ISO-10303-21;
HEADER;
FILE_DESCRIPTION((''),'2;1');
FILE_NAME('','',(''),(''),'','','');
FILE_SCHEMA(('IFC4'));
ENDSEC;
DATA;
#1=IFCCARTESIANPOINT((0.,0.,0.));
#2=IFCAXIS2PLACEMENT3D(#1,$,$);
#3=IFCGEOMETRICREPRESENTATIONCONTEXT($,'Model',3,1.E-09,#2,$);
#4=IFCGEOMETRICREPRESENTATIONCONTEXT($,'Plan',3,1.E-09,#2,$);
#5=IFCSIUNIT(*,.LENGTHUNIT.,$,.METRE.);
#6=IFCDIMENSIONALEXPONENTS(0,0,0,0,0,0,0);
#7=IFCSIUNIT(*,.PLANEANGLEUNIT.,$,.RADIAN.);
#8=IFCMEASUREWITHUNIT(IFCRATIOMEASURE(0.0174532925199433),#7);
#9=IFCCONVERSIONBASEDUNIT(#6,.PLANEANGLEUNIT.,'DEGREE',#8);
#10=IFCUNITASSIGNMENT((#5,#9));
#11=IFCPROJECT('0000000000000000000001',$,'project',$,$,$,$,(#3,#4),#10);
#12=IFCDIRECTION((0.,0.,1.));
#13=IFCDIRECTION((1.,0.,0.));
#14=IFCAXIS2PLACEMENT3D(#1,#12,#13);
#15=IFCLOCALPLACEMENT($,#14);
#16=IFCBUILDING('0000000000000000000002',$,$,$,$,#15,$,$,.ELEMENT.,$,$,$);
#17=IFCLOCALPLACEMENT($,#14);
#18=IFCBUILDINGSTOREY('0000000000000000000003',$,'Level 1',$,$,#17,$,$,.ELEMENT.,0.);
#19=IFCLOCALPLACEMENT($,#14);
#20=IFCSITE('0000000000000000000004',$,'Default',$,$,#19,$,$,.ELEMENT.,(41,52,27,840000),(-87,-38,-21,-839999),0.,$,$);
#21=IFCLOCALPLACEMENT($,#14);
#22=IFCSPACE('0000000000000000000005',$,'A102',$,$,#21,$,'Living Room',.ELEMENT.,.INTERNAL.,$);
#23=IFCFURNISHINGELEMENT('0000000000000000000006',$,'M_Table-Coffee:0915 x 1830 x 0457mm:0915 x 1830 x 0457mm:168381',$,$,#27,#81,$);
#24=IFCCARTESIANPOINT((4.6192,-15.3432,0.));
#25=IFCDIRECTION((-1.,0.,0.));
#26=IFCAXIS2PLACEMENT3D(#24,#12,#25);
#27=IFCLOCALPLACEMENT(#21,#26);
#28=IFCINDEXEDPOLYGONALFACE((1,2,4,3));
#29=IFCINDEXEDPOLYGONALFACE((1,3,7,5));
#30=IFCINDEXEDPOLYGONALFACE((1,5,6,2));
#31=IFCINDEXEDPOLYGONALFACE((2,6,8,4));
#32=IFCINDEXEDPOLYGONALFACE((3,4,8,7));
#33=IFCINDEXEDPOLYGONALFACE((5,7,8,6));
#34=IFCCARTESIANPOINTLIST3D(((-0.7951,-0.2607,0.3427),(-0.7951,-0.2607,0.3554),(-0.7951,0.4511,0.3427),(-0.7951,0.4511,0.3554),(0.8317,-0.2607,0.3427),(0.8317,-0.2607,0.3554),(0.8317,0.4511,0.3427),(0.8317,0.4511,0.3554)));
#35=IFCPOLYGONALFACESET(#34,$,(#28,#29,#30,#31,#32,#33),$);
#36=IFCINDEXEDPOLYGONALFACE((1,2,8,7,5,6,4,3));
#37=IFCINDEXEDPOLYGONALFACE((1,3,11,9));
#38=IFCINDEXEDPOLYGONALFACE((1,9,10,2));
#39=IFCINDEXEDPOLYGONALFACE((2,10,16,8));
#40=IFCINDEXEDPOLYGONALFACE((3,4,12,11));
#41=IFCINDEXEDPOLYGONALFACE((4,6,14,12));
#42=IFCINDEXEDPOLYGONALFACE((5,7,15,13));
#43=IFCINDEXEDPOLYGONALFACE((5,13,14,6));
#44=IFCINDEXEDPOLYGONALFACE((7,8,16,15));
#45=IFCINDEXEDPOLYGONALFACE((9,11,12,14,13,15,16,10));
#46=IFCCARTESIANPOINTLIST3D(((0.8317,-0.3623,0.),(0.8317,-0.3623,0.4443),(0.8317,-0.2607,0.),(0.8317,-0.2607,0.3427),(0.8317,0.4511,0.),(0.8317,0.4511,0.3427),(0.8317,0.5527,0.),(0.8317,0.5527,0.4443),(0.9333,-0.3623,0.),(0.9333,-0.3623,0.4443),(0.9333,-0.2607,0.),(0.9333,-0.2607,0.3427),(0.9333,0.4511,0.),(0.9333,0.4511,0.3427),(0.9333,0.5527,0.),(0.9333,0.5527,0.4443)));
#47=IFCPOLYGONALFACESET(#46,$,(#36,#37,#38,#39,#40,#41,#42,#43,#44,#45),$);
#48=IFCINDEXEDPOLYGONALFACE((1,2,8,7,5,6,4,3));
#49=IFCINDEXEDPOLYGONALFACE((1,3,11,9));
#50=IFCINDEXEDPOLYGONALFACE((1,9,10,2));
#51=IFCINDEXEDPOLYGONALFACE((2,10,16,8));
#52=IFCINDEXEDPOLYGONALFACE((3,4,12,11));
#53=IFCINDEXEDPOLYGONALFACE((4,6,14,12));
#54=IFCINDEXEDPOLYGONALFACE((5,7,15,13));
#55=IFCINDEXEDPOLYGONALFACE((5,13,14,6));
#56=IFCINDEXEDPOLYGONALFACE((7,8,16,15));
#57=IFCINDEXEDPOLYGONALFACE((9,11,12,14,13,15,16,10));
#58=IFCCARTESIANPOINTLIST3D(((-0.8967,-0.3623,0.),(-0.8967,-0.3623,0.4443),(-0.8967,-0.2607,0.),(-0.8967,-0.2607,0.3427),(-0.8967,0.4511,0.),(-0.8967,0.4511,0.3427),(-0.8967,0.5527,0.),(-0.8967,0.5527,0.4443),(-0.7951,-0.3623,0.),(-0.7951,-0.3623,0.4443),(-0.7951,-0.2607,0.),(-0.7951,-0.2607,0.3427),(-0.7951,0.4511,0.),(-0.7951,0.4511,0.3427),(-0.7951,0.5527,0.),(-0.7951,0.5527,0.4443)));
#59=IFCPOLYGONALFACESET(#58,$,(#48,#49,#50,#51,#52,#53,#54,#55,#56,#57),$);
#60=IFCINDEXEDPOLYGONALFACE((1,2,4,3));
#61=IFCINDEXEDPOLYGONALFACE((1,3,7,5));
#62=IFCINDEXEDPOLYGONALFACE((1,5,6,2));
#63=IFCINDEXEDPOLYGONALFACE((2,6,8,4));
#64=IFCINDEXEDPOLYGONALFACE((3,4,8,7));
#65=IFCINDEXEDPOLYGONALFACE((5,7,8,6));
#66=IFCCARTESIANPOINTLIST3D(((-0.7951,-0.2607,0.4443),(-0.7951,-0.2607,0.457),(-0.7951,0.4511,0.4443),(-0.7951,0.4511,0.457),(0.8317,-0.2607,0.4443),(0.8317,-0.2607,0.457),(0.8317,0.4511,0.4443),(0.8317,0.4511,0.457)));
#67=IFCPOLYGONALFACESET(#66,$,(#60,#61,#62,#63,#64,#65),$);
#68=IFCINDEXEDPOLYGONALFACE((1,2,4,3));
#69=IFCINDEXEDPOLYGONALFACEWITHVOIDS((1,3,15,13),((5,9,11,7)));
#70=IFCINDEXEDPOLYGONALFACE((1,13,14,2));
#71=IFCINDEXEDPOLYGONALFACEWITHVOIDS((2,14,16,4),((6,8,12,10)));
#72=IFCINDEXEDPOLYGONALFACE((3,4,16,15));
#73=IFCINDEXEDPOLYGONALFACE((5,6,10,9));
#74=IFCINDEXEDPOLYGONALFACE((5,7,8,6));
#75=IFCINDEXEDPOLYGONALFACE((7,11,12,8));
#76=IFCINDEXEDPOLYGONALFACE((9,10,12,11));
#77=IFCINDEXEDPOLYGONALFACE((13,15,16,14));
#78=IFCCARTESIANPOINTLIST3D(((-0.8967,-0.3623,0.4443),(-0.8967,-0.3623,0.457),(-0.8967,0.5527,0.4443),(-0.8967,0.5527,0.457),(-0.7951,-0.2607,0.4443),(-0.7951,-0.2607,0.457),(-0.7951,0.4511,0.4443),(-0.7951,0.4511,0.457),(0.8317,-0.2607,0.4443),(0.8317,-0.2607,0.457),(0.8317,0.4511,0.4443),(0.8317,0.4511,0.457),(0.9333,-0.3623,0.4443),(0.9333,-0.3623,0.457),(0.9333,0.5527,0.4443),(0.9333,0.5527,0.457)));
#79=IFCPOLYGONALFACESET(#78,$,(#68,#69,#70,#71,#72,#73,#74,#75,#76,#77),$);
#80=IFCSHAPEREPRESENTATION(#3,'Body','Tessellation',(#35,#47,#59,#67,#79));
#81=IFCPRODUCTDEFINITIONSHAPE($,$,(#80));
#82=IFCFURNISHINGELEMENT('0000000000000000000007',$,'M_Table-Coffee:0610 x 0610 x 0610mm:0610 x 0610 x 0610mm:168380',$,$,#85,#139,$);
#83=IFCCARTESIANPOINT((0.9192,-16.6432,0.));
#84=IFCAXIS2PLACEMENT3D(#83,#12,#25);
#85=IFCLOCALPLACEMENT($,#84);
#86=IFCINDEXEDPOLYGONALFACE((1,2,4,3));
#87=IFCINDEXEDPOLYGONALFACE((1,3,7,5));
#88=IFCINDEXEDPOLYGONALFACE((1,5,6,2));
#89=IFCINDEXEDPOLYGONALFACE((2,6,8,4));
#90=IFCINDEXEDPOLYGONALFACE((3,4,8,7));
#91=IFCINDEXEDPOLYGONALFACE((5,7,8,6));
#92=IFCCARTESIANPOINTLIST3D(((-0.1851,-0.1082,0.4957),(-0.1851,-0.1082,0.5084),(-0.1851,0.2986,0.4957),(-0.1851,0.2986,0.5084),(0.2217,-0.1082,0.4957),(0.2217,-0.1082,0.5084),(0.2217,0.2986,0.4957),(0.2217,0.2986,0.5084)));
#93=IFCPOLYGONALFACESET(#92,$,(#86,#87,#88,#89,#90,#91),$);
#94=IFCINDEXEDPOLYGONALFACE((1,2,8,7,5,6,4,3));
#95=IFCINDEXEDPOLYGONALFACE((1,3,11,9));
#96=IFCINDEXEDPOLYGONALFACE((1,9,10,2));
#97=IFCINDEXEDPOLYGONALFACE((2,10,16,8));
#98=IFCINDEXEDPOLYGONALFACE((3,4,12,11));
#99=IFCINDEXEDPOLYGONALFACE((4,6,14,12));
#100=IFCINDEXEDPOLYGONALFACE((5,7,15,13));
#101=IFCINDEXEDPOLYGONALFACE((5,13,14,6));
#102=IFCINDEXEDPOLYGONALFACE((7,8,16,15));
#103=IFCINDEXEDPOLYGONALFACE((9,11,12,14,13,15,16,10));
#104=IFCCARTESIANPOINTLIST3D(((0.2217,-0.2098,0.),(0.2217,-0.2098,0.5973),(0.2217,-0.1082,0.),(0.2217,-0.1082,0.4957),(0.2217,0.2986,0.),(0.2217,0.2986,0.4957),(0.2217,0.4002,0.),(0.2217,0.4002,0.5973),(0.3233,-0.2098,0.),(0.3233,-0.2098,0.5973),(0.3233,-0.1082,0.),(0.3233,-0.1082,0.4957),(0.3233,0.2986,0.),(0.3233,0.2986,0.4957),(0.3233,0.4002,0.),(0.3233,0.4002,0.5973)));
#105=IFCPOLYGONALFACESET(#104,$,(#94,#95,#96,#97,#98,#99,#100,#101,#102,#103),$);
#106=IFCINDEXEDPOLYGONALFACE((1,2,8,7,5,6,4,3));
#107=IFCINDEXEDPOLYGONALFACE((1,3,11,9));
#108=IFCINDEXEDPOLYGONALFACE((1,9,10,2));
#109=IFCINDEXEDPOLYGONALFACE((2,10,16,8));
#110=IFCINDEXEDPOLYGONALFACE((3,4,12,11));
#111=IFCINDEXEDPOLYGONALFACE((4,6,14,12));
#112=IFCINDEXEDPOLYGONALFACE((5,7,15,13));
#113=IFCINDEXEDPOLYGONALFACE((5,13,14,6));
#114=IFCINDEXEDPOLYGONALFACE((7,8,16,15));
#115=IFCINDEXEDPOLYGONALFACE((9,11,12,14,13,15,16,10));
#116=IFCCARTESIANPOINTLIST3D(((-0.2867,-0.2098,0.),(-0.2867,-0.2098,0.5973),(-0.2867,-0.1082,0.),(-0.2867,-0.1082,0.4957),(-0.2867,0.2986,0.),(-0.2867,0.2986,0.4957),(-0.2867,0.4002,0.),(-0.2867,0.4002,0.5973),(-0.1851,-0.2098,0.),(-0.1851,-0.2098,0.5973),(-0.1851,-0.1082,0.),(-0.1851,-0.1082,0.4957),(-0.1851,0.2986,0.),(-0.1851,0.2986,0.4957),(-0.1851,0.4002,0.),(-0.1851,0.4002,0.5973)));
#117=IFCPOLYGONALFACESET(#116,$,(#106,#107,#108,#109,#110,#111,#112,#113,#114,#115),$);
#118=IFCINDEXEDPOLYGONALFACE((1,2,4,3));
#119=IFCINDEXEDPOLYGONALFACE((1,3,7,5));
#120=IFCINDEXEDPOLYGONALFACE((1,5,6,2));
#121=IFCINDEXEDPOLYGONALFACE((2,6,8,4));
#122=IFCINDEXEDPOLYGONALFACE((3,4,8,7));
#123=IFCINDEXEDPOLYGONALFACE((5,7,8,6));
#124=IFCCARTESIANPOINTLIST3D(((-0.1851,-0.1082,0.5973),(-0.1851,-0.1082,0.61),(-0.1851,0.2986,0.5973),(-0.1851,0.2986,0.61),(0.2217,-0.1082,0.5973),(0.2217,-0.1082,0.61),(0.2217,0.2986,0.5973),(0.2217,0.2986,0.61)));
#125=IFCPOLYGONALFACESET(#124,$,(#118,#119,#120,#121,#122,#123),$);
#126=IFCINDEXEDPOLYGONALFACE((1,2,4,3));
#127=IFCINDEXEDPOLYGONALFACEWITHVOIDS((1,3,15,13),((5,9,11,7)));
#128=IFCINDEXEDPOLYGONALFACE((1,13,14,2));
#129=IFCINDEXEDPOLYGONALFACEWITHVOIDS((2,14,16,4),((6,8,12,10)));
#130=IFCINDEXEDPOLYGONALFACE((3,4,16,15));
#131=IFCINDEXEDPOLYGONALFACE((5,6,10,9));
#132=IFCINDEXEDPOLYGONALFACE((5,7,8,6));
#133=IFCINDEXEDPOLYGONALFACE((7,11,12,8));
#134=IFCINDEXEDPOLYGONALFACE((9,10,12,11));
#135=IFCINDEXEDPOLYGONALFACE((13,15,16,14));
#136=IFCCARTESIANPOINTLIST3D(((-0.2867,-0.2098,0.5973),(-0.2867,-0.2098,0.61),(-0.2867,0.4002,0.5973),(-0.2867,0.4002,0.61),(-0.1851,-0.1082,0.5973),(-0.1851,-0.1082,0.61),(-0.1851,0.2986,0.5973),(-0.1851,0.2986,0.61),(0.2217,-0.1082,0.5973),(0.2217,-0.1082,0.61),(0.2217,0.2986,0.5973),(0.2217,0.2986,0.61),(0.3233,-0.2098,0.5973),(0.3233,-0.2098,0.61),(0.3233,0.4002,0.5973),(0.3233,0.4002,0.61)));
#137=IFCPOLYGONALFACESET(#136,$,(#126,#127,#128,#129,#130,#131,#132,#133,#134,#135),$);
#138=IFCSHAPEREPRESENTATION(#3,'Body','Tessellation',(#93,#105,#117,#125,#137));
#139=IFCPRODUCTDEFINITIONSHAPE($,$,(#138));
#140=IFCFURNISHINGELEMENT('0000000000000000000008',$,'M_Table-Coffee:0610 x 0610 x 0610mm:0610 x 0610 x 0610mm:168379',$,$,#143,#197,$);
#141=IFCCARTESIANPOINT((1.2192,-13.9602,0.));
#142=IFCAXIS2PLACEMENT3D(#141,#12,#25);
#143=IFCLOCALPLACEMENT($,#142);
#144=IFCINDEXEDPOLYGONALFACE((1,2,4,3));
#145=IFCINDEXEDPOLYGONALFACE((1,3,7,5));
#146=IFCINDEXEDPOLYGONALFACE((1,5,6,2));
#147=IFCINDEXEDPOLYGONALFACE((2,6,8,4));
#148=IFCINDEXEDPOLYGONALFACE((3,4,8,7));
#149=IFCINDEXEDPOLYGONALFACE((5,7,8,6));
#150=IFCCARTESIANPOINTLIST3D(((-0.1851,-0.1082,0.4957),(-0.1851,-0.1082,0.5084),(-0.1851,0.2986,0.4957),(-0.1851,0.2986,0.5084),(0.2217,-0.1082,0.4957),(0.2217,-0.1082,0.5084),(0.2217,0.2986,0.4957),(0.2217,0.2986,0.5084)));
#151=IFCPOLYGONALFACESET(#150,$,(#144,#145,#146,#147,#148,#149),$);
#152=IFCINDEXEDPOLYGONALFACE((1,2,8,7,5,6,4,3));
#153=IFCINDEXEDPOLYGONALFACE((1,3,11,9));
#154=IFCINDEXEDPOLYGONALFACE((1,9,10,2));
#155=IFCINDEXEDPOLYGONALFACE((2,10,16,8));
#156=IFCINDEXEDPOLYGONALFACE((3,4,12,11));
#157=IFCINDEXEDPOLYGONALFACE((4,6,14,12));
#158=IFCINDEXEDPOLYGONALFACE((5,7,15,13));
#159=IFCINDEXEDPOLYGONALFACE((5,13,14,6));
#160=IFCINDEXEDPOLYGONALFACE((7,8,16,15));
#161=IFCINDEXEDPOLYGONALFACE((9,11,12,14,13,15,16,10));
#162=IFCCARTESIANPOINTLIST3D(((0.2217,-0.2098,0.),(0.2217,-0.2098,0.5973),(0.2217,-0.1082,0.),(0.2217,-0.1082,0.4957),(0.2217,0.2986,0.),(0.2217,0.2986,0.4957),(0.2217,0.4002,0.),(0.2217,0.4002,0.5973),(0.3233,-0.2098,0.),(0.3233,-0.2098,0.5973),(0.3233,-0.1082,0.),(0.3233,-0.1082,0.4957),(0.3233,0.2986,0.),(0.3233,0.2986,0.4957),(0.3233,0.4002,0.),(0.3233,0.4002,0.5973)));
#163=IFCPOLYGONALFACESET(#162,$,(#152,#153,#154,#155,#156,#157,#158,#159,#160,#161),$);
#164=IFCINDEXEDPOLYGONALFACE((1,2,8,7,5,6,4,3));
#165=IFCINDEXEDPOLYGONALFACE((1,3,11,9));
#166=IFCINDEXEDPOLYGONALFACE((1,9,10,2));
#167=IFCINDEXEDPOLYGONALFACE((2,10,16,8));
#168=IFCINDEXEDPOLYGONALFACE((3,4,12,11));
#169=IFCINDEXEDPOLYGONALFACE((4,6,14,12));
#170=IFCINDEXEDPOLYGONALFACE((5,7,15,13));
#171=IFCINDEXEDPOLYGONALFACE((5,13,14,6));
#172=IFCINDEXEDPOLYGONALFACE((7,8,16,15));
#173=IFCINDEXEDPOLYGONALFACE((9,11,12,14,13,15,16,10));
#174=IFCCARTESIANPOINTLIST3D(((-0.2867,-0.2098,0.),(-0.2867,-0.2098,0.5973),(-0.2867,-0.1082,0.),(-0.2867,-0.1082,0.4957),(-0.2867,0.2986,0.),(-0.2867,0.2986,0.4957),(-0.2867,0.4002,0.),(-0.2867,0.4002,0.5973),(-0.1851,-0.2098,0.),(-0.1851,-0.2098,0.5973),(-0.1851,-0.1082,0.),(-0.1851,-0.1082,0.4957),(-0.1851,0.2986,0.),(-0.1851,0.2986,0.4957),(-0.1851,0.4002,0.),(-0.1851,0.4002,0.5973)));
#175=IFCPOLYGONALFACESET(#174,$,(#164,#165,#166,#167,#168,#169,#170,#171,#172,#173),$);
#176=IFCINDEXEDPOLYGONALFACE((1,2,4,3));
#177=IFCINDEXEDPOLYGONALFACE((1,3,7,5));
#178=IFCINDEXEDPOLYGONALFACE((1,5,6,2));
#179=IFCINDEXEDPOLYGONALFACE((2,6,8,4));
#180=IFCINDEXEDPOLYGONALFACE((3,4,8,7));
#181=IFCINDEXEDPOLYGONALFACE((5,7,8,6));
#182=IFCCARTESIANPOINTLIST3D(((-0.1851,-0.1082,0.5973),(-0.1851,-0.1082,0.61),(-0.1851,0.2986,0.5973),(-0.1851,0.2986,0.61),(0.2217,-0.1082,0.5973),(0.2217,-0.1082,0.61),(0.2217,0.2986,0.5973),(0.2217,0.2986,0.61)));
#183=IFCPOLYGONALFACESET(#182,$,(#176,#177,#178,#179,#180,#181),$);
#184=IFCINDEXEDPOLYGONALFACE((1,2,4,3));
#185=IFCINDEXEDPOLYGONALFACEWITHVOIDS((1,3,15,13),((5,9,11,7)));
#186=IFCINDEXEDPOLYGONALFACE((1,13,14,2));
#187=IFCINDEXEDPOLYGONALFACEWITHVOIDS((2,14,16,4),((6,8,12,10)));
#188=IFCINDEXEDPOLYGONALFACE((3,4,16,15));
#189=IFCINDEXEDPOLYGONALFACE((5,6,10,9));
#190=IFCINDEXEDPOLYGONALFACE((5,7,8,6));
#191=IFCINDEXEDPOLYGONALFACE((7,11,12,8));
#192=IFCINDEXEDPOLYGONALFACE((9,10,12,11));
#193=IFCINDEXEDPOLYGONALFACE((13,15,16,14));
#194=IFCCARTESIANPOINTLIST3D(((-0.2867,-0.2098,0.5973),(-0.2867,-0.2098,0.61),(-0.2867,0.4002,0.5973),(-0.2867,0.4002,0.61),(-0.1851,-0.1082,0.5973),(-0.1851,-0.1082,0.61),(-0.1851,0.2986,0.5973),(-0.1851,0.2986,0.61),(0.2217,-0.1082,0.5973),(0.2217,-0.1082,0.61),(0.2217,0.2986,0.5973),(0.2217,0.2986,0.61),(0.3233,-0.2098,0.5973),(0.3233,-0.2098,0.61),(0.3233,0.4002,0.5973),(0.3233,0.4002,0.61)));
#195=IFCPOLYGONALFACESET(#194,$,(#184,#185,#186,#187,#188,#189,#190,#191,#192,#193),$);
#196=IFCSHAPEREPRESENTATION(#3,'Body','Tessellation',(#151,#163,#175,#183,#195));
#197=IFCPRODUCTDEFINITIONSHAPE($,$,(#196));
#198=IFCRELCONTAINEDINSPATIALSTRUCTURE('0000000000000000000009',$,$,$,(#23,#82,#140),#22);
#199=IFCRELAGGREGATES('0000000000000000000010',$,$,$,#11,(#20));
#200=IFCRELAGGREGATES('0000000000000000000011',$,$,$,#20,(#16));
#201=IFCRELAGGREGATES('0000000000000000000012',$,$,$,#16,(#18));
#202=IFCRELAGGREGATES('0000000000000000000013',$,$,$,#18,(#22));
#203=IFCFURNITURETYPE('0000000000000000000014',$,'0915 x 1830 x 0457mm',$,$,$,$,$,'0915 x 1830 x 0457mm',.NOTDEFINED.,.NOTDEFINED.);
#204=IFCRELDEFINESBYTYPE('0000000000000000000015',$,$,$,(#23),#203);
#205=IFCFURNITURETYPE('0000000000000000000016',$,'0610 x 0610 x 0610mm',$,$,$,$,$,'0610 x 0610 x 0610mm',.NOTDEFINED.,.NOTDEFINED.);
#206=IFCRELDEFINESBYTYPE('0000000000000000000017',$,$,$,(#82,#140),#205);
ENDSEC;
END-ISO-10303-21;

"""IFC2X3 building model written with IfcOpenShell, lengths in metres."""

from ifc_helpers import new_model, entity, si_unit, converted_unit, frame, origin, origin_with_axes, origin_2d_with_axis, place, context, project, spatial, polyline, rectangle, outline, extrude, source, transform, mapped, type_object, type_shapes, element, save


model = new_model("IFC2X3")

# Units and contexts
model_context = context("Model", 3, precision=1e-09, world=origin())
plan_context = context("Plan", 3, precision=1e-09, world=origin())
ifc_project = project(units=[si_unit("LENGTHUNIT", "METRE"), converted_unit("PLANEANGLEUNIT", "DEGREE", entity("IfcRatioMeasure", 0.0174532925199433), si_unit("PLANEANGLEUNIT", "RADIAN"), dimensions=[0, 0, 0, 0, 0, 0, 0])], contexts=[model_context, plan_context])

# Site, building, storey, space
site_placement = place(None, origin_with_axes())
site = spatial("IfcSite", under=ifc_project, at=site_placement, Name="Default", CompositionType="ELEMENT", RefLatitude=(41, 52, 27, 840000), RefLongitude=(-87, -38, -21, -839999), RefElevation=0.0)
building_placement = place(None, origin_with_axes())
building = spatial("IfcBuilding", under=site, at=building_placement, CompositionType="ELEMENT")
storey_placement = place(None, origin_with_axes())
storey = spatial("IfcBuildingStorey", under=building, at=storey_placement, Name="Level 1", CompositionType="ELEMENT", Elevation=0.0)
space_placement = place(None, origin_with_axes())
space = spatial("IfcSpace", under=storey, at=space_placement, Name="A102", LongName="Living Room", CompositionType="ELEMENT", InteriorOrExteriorSpace="INTERNAL")

# Furnishing elements
furniture_type_1 = type_object("IfcFurnitureType", Name="0915 x 1830 x 0457mm", ElementType="0915 x 1830 x 0457mm", AssemblyPlace="NOTDEFINED")
shared_shape_1 = source(origin(), model_context, "Body", "SweptSolid", [
    extrude(rectangle(XDim=1.6268, YDim=0.7118, at=origin_2d_with_axis()), frame((0.0183, 0.0952, 0.3427), z_axis=(0.0, 0.0, 1.0), x_axis=(-1.0, 0.0, 0.0)), (0.0, 0.0, 1.0), 0.0127),
    extrude(outline(polyline([(-0.1967, -0.4575), (0.2475, -0.4575), (0.2475, 0.4575), (-0.1967, 0.4575), (-0.1967, 0.3559), (0.146, 0.3559), (0.146, -0.3559), (-0.1967, -0.3559), (-0.1967, -0.4575)])), frame((0.8317, 0.0952, 0.1967), z_axis=(1.0, 0.0, 0.0), x_axis=(0.0, 0.0, 1.0)), (0.0, 0.0, 1.0), 0.1016),
    extrude(outline(polyline([(-0.4575, -0.2476), (0.4575, -0.2476), (0.4575, 0.1968), (0.3559, 0.1968), (0.3559, -0.1459), (-0.3559, -0.1459), (-0.3559, 0.1968), (-0.4575, 0.1968), (-0.4575, -0.2476)])), frame((-0.8967, 0.0952, 0.1968), z_axis=(1.0, 0.0, 0.0), x_axis=(0.0, -1.0, 0.0)), (0.0, 0.0, 1.0), 0.1016),
    extrude(rectangle(XDim=1.6268, YDim=0.7118, at=origin_2d_with_axis()), frame((0.0183, 0.0952, 0.4443), z_axis=(0.0, 0.0, 1.0), x_axis=(-1.0, 0.0, 0.0)), (0.0, 0.0, 1.0), 0.0127),
    extrude(outline(polyline([(-0.915, -0.4575), (0.915, -0.4575), (0.915, 0.4575), (-0.915, 0.4575), (-0.915, -0.4575)]), holes=[polyline([(-0.8134, -0.3559), (-0.8134, 0.3559), (0.8134, 0.3559), (0.8134, -0.3559), (-0.8134, -0.3559)])]), frame((0.0183, 0.0952, 0.4443), z_axis=(0.0, 0.0, 1.0), x_axis=(-1.0, 0.0, 0.0)), (0.0, 0.0, 1.0), 0.0127),
])
type_shapes(furniture_type_1, [shared_shape_1])
furnishing_placement = place(space_placement, frame((4.6192, -15.3432, 0.0), z_axis=(0.0, 0.0, 1.0), x_axis=(-1.0, 0.0, 0.0)))
element("IfcFurnishingElement", 1, at=furnishing_placement, inside=space, type_object=furniture_type_1, Name="M_Table-Coffee:0915 x 1830 x 0457mm:0915 x 1830 x 0457mm:168381", context=model_context, shape_type="MappedRepresentation", body=[
    mapped(shared_shape_1, transform((0.0, 0.0, 0.0), scale=1.0)),
])
furniture_type_2 = type_object("IfcFurnitureType", Name="0610 x 0610 x 0610mm", ElementType="0610 x 0610 x 0610mm", AssemblyPlace="NOTDEFINED")
shared_shape_2 = source(origin(), model_context, "Body", "SweptSolid", [
    extrude(rectangle(XDim=0.4068, YDim=0.4068, at=origin_2d_with_axis()), frame((0.0183, 0.0952, 0.4957), z_axis=(0.0, 0.0, 1.0), x_axis=(-1.0, 0.0, 0.0)), (0.0, 0.0, 1.0), 0.0127),
    extrude(outline(polyline([(-0.2732, -0.305), (0.324, -0.305), (0.324, 0.305), (-0.2732, 0.305), (-0.2732, 0.2034), (0.2225, 0.2034), (0.2225, -0.2034), (-0.2732, -0.2034), (-0.2732, -0.305)])), frame((0.2217, 0.0952, 0.2732), z_axis=(1.0, 0.0, 0.0), x_axis=(0.0, 0.0, 1.0)), (0.0, 0.0, 1.0), 0.1016),
    extrude(outline(polyline([(-0.305, -0.3241), (0.305, -0.3241), (0.305, 0.2733), (0.2034, 0.2733), (0.2034, -0.2224), (-0.2034, -0.2224), (-0.2034, 0.2733), (-0.305, 0.2733), (-0.305, -0.3241)])), frame((-0.2867, 0.0952, 0.2733), z_axis=(1.0, 0.0, 0.0), x_axis=(0.0, -1.0, 0.0)), (0.0, 0.0, 1.0), 0.1016),
    extrude(rectangle(XDim=0.4068, YDim=0.4068, at=origin_2d_with_axis()), frame((0.0183, 0.0952, 0.5973), z_axis=(0.0, 0.0, 1.0), x_axis=(-1.0, 0.0, 0.0)), (0.0, 0.0, 1.0), 0.0127),
    extrude(outline(polyline([(-0.305, -0.305), (0.305, -0.305), (0.305, 0.305), (-0.305, 0.305), (-0.305, -0.305)]), holes=[polyline([(-0.2034, -0.2034), (-0.2034, 0.2034), (0.2034, 0.2034), (0.2034, -0.2034), (-0.2034, -0.2034)])]), frame((0.0183, 0.0952, 0.5973), z_axis=(0.0, 0.0, 1.0), x_axis=(-1.0, 0.0, 0.0)), (0.0, 0.0, 1.0), 0.0127),
])
type_shapes(furniture_type_2, [shared_shape_2])
for number, where, z_axis, x_axis, name in (
    (2, (0.9192, -16.6432, 0.0), (0.0, 0.0, 1.0), (-1.0, 0.0, 0.0), "M_Table-Coffee:0610 x 0610 x 0610mm:0610 x 0610 x 0610mm:168380"),
    (3, (1.2192, -13.9602, 0.0), (0.0, 0.0, 1.0), (-1.0, 0.0, 0.0), "M_Table-Coffee:0610 x 0610 x 0610mm:0610 x 0610 x 0610mm:168379"),
):
    element("IfcFurnishingElement", number, at=place(None, frame(where, z_axis=z_axis, x_axis=x_axis)), inside=space, type_object=furniture_type_2, Name=name, context=model_context, shape_type="MappedRepresentation", body=[
        mapped(shared_shape_2, transform((0.0, 0.0, 0.0), scale=1.0)),
    ])

save(model, "model.ifc")
